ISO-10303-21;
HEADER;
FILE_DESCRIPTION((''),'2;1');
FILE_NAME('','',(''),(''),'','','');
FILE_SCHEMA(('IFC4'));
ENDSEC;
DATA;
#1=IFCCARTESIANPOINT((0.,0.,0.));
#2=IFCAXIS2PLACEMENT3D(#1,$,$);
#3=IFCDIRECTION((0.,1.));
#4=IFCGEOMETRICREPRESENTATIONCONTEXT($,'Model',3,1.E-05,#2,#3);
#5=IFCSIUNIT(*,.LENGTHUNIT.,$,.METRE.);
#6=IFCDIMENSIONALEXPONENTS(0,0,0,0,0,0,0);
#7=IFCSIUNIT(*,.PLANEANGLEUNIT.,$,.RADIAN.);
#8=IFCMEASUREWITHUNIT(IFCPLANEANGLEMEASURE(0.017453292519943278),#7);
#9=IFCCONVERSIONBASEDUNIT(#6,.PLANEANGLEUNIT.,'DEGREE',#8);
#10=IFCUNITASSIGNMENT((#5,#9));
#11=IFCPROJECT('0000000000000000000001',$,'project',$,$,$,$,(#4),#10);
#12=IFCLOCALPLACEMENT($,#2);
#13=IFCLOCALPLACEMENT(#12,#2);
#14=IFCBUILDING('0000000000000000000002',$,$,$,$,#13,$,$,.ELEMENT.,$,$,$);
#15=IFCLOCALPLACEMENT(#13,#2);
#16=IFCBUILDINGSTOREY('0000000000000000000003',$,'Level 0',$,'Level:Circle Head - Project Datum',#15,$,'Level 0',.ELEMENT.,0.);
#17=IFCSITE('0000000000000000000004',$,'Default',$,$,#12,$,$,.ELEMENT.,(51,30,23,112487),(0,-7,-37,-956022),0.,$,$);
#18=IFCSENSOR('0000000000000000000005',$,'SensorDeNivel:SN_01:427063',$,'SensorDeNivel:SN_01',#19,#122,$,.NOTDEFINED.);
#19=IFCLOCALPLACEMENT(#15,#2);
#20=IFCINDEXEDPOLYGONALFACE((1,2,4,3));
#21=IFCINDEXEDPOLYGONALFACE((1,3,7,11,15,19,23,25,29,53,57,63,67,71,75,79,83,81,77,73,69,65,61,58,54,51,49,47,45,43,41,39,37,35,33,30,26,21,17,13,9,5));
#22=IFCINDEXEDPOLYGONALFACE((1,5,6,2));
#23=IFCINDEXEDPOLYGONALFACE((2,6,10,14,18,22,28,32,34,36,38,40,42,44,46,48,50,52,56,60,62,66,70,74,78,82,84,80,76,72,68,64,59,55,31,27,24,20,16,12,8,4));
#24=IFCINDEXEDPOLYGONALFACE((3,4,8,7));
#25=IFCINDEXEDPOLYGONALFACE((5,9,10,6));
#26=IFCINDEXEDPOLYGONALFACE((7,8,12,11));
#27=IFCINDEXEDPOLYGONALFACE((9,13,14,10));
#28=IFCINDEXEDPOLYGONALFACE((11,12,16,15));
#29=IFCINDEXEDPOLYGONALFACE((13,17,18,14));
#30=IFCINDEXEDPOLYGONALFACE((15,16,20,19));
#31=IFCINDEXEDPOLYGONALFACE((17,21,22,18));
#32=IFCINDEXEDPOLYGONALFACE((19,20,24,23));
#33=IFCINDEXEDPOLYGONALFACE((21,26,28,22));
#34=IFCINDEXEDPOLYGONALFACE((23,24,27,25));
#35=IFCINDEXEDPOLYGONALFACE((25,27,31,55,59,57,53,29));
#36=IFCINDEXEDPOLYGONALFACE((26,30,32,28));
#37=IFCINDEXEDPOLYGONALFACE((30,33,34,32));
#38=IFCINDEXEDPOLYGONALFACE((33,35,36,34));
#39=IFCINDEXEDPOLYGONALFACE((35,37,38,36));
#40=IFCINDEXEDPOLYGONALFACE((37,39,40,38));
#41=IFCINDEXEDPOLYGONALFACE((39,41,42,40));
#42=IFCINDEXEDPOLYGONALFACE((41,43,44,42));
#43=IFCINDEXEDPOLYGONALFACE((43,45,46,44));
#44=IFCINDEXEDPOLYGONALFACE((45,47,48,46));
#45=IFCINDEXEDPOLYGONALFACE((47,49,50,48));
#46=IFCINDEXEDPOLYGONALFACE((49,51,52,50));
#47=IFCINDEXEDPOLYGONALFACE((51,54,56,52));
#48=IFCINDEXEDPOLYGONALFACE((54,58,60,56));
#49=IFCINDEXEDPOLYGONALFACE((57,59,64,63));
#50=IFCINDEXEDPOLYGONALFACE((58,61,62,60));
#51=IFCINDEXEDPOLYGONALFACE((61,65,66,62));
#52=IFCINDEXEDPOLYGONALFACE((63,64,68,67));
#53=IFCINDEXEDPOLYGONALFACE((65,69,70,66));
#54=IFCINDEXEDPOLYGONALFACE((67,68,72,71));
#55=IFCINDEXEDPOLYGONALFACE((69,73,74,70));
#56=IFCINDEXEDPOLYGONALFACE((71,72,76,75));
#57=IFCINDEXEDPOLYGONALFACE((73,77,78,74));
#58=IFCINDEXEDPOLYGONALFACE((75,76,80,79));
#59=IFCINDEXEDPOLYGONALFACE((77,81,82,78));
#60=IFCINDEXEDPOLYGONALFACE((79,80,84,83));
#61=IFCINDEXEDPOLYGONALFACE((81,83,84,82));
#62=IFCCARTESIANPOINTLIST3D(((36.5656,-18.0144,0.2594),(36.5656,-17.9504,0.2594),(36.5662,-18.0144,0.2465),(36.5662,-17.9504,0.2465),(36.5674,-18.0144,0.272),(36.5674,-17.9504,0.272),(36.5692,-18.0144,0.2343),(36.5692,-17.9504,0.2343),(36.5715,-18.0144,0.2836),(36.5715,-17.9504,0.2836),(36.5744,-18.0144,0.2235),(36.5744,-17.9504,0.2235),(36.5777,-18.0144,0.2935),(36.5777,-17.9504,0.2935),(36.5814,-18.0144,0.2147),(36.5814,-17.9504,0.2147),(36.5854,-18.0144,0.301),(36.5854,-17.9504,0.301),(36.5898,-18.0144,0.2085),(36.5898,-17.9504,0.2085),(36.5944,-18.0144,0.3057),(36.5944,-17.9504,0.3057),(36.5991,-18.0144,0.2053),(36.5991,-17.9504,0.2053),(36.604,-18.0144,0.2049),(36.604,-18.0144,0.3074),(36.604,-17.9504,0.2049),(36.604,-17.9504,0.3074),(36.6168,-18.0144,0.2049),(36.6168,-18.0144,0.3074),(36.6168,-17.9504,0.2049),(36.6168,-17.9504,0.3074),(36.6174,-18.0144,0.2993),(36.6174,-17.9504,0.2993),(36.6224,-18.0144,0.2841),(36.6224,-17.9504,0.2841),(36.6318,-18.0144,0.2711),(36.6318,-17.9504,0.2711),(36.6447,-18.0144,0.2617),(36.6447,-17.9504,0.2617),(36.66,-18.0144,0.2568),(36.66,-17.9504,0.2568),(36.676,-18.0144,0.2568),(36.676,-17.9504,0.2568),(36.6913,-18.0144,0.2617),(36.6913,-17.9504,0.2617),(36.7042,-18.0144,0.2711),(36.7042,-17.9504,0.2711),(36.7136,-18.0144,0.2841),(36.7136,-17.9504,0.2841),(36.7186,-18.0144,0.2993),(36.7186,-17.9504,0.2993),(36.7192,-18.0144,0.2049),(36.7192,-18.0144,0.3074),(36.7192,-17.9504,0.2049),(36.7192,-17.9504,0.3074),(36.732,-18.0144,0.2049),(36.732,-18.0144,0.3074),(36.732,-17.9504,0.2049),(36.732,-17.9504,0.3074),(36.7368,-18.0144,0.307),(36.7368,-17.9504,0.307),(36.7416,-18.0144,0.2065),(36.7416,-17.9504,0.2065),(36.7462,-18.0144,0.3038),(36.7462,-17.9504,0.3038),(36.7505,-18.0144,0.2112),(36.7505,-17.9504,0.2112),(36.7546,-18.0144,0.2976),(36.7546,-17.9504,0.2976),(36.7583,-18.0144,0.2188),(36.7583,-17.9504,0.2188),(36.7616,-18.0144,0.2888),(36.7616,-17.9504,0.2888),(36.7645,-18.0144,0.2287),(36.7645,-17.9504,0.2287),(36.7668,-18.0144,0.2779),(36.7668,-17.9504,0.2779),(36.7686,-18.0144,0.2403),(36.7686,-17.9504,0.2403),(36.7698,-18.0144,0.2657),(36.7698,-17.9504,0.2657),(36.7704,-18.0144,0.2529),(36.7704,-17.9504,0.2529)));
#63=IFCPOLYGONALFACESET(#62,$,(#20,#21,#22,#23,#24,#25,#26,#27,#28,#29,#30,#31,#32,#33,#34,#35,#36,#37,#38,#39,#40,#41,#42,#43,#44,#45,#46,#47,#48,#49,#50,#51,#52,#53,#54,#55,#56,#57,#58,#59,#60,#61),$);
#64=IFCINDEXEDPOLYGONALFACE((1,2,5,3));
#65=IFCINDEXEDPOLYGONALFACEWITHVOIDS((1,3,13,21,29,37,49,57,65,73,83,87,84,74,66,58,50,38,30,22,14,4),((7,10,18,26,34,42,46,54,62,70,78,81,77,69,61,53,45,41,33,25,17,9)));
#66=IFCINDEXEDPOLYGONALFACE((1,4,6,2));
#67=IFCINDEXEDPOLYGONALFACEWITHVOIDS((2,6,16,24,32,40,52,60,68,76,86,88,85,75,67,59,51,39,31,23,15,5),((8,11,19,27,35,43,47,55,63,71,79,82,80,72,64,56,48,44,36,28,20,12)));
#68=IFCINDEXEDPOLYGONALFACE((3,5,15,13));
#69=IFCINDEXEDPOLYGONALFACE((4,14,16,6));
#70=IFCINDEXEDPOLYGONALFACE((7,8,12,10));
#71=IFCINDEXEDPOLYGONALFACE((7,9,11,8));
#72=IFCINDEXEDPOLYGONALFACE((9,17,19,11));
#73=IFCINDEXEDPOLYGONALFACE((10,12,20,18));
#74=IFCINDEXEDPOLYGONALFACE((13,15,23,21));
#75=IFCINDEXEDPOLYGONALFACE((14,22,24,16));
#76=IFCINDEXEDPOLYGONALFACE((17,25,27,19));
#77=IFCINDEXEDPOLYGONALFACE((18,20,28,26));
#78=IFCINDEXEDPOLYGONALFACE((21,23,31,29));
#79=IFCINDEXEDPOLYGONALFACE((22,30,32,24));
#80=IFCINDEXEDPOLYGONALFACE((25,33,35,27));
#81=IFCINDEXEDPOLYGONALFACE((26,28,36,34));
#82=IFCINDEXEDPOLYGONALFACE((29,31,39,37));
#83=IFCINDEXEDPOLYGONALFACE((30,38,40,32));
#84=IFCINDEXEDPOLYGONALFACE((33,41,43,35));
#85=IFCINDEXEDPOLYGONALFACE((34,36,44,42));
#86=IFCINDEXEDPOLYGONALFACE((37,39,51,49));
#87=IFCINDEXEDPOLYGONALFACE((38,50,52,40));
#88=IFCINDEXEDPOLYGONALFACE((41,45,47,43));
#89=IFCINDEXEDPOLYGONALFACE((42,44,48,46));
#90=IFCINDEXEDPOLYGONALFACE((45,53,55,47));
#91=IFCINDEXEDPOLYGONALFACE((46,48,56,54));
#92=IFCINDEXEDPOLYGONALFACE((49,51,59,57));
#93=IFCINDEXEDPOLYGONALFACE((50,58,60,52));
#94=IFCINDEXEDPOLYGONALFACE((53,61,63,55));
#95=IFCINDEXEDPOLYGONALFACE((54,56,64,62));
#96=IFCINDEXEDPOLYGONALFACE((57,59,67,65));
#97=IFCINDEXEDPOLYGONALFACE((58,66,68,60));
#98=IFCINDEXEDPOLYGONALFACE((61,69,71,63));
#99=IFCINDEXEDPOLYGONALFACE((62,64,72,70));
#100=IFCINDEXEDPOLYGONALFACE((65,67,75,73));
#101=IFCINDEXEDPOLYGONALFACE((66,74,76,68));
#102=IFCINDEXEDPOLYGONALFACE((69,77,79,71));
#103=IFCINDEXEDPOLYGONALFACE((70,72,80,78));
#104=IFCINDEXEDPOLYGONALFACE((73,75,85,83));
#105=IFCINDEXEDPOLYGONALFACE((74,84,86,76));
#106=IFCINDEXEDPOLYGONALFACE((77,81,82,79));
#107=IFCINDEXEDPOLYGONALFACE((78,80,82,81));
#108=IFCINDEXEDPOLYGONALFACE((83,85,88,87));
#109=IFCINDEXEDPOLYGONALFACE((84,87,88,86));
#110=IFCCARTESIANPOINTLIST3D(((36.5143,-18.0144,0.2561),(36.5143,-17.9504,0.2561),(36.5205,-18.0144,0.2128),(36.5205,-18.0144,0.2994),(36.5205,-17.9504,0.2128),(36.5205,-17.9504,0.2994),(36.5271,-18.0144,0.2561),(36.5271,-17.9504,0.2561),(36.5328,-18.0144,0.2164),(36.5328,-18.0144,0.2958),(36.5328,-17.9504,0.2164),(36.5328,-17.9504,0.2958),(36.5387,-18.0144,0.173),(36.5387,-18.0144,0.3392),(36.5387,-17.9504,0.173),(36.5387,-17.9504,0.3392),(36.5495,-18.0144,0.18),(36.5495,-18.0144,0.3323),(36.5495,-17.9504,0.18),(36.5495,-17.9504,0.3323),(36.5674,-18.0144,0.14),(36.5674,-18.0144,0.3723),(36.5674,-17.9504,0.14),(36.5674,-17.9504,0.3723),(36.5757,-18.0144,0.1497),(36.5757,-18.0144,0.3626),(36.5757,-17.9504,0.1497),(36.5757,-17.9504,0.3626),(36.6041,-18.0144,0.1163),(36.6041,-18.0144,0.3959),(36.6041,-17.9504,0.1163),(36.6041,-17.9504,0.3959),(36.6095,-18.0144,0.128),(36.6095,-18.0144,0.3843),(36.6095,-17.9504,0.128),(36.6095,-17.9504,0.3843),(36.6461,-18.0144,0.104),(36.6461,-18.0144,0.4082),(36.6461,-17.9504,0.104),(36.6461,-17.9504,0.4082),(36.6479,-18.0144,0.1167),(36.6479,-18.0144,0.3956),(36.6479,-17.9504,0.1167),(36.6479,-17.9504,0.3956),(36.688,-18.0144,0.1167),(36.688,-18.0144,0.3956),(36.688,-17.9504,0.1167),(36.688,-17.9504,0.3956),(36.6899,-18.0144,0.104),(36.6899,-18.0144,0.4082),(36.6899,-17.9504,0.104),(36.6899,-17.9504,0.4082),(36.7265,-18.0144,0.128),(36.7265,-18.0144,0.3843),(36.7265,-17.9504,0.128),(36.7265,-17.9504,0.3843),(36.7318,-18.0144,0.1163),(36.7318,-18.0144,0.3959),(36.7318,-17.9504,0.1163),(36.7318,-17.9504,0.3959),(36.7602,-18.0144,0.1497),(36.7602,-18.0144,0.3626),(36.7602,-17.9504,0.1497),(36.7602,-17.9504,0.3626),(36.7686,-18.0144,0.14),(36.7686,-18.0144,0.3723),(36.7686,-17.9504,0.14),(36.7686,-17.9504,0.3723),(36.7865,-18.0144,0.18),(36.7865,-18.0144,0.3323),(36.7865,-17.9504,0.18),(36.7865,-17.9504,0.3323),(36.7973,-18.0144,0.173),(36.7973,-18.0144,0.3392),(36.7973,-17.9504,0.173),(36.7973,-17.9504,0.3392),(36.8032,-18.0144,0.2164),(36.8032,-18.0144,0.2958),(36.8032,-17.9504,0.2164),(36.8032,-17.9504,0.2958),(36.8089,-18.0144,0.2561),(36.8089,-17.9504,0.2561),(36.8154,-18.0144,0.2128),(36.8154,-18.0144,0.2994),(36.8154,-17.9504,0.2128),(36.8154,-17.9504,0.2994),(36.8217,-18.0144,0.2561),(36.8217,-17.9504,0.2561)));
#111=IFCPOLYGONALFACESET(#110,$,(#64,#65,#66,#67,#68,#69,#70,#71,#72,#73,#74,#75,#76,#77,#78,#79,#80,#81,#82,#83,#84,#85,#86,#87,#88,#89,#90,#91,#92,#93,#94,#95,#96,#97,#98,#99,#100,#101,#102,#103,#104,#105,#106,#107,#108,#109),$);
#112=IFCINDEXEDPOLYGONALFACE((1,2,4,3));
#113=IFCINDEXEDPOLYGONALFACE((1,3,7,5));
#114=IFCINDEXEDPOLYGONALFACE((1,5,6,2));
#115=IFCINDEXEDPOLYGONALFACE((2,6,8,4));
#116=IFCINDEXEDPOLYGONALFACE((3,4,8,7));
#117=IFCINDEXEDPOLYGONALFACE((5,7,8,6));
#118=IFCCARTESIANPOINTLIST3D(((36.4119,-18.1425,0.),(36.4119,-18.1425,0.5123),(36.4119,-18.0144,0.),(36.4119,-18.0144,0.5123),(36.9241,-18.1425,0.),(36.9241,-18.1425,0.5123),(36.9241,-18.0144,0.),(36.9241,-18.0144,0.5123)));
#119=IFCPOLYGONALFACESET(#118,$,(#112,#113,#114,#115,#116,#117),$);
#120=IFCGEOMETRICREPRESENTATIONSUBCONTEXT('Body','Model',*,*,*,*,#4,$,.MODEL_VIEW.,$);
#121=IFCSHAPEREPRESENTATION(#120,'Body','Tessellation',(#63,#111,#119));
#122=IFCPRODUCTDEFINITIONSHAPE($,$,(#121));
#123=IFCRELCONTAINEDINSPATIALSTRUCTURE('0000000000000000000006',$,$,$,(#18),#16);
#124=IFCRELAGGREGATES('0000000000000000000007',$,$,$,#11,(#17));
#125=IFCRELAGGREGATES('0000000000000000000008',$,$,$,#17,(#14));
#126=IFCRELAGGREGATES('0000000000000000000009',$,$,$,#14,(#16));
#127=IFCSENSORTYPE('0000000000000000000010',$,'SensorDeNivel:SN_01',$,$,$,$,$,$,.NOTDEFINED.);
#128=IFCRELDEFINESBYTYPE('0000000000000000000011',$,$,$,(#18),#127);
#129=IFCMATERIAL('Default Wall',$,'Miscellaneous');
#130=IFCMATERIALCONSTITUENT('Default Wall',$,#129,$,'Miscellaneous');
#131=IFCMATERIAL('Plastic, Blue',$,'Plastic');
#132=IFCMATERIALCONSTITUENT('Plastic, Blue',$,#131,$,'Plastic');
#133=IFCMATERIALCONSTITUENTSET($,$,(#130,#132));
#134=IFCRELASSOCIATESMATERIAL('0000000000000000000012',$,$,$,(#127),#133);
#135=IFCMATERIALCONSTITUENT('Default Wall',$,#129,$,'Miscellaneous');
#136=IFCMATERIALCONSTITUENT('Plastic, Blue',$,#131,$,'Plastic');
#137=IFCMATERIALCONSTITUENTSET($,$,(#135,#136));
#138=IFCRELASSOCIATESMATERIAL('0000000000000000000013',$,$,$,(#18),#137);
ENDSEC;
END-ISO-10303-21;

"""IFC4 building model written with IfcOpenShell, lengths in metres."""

from ifc_helpers import new_model, entity, si_unit, converted_unit, direction, frame, origin, place, context, subcontext, project, spatial, arc, indexed_curve, outline, extrude, source, transform, mapped, material, constituent, constituent_set, type_object, type_shapes, element, save


model = new_model("IFC4")

# Units and contexts
model_context = context("Model", 3, precision=1e-05, world=origin(), true_north=direction((0.0, 1.0)))
body_context = subcontext(model_context, "Body", "Model", "MODEL_VIEW")
ifc_project = project(units=[si_unit("LENGTHUNIT", "METRE"), converted_unit("PLANEANGLEUNIT", "DEGREE", entity("IfcPlaneAngleMeasure", 0.017453292519943278), si_unit("PLANEANGLEUNIT", "RADIAN"), dimensions=[0, 0, 0, 0, 0, 0, 0])], contexts=[model_context])

# Site, building, storey
site_placement = place(None, origin())
site = spatial("IfcSite", under=ifc_project, at=site_placement, Name="Default", CompositionType="ELEMENT", RefLatitude=(51, 30, 23, 112487), RefLongitude=(0, -7, -37, -956022), RefElevation=0.0)
building_placement = place(site_placement, origin())
building = spatial("IfcBuilding", under=site, at=building_placement, CompositionType="ELEMENT")
storey_placement = place(building_placement, origin())
storey = spatial("IfcBuildingStorey", under=building, at=storey_placement, Name="Level 0", ObjectType="Level:Circle Head - Project Datum", LongName="Level 0", CompositionType="ELEMENT", Elevation=0.0)

# Sensor
ifc_material_1 = material(Name="Default Wall", Category="Miscellaneous")
ifc_constituent_1 = constituent(ifc_material_1, Name="Default Wall", Category="Miscellaneous")
ifc_material_2 = material(Name="Plastic, Blue", Category="Plastic")
ifc_constituent_2 = constituent(ifc_material_2, Name="Plastic, Blue", Category="Plastic")
ifc_constituent_set_1 = constituent_set(constituents=[ifc_constituent_1, ifc_constituent_2])
ifc_constituent_3 = constituent(ifc_material_1, Name="Default Wall", Category="Miscellaneous")
ifc_constituent_4 = constituent(ifc_material_2, Name="Plastic, Blue", Category="Plastic")
ifc_constituent_set_2 = constituent_set(constituents=[ifc_constituent_3, ifc_constituent_4])
sensor_type_1 = type_object("IfcSensorType", Name="SensorDeNivel:SN_01", PredefinedType="NOTDEFINED", material=ifc_constituent_set_2)
shared_shape_1 = source(origin(), body_context, "Body", "SweptSolid", [
    extrude(outline(indexed_curve([(0.0512, -0.0556), (0.064, -0.0556), (0.0736, -0.054), (0.0825, -0.0493), (0.0903, -0.0417), (0.0965, -0.0318), (0.1006, -0.0202), (0.1024, -0.0076), (0.1018, 0.0052), (0.0988, 0.0174), (0.0936, 0.0283), (0.0866, 0.037), (0.0782, 0.0432), (0.0689, 0.0464), (0.064, 0.0468), (0.0512, 0.0468), (0.0506, 0.0388), (0.0456, 0.0236), (0.0362, 0.0106), (0.0233, 0.0012), (0.008, -0.0038), (-0.008, -0.0038), (-0.0233, 0.0012), (-0.0362, 0.0106), (-0.0456, 0.0236), (-0.0506, 0.0388), (-0.0512, 0.0468), (-0.064, 0.0468), (-0.0736, 0.0452), (-0.0825, 0.0405), (-0.0903, 0.0329), (-0.0965, 0.023), (-0.1006, 0.0114), (-0.1024, -0.0012), (-0.1018, -0.014), (-0.0988, -0.0262), (-0.0936, -0.0371), (-0.0866, -0.0458), (-0.0782, -0.052), (-0.0689, -0.0552), (-0.064, -0.0556), (-0.0512, -0.0556), (0.0512, -0.0556)], self_intersect=False)), frame((0.0, -0.1281, 0.2605), z_axis=(0.0, 1.0, 0.0), x_axis=(-1.0, 0.0, 0.0)), (0.0, 0.0, 1.0), 0.064),
    extrude(outline(indexed_curve([(-0.1537, 0.0), (0.0, -0.1537), (0.1537, 0.0), (0.0, 0.1537)], segments=[arc(1, 2, 3), arc(3, 4, 1)], self_intersect=False), holes=[indexed_curve([(-0.1409, 0.0), (0.0, 0.1409), (0.1409, 0.0), (0.0, -0.1409)], segments=[arc(1, 2, 3), arc(3, 4, 1)], self_intersect=False)]), frame((0.0, -0.1281, 0.2561), z_axis=(0.0, 1.0, 0.0), x_axis=(1.0, 0.0, 0.0)), (0.0, 0.0, 1.0), 0.064),
    extrude(outline(indexed_curve([(-0.2561, -0.064), (0.2561, -0.064), (0.2561, 0.064), (-0.2561, 0.064), (-0.2561, -0.064)], self_intersect=False)), frame((0.0, 0.0, 0.0), z_axis=(0.0, 0.0, 1.0), x_axis=(-1.0, 0.0, 0.0)), (0.0, 0.0, 1.0), 0.5123),
])
type_shapes(sensor_type_1, [shared_shape_1])
sensor_1_placement = place(storey_placement, frame((36.668, -18.0785, 0.0), z_axis=(0.0, 0.0, 1.0), x_axis=(-1.0, 0.0, 0.0)))
element("IfcSensor", 1, at=sensor_1_placement, inside=storey, type_object=sensor_type_1, material=ifc_constituent_set_1, Name="SensorDeNivel:SN_01:427063", ObjectType="SensorDeNivel:SN_01", PredefinedType="NOTDEFINED", context=body_context, shape_type="MappedRepresentation", body=[
    mapped(shared_shape_1, transform((0.0, 0.0, 0.0), scale=1.0)),
])

save(model, "model.ifc")
